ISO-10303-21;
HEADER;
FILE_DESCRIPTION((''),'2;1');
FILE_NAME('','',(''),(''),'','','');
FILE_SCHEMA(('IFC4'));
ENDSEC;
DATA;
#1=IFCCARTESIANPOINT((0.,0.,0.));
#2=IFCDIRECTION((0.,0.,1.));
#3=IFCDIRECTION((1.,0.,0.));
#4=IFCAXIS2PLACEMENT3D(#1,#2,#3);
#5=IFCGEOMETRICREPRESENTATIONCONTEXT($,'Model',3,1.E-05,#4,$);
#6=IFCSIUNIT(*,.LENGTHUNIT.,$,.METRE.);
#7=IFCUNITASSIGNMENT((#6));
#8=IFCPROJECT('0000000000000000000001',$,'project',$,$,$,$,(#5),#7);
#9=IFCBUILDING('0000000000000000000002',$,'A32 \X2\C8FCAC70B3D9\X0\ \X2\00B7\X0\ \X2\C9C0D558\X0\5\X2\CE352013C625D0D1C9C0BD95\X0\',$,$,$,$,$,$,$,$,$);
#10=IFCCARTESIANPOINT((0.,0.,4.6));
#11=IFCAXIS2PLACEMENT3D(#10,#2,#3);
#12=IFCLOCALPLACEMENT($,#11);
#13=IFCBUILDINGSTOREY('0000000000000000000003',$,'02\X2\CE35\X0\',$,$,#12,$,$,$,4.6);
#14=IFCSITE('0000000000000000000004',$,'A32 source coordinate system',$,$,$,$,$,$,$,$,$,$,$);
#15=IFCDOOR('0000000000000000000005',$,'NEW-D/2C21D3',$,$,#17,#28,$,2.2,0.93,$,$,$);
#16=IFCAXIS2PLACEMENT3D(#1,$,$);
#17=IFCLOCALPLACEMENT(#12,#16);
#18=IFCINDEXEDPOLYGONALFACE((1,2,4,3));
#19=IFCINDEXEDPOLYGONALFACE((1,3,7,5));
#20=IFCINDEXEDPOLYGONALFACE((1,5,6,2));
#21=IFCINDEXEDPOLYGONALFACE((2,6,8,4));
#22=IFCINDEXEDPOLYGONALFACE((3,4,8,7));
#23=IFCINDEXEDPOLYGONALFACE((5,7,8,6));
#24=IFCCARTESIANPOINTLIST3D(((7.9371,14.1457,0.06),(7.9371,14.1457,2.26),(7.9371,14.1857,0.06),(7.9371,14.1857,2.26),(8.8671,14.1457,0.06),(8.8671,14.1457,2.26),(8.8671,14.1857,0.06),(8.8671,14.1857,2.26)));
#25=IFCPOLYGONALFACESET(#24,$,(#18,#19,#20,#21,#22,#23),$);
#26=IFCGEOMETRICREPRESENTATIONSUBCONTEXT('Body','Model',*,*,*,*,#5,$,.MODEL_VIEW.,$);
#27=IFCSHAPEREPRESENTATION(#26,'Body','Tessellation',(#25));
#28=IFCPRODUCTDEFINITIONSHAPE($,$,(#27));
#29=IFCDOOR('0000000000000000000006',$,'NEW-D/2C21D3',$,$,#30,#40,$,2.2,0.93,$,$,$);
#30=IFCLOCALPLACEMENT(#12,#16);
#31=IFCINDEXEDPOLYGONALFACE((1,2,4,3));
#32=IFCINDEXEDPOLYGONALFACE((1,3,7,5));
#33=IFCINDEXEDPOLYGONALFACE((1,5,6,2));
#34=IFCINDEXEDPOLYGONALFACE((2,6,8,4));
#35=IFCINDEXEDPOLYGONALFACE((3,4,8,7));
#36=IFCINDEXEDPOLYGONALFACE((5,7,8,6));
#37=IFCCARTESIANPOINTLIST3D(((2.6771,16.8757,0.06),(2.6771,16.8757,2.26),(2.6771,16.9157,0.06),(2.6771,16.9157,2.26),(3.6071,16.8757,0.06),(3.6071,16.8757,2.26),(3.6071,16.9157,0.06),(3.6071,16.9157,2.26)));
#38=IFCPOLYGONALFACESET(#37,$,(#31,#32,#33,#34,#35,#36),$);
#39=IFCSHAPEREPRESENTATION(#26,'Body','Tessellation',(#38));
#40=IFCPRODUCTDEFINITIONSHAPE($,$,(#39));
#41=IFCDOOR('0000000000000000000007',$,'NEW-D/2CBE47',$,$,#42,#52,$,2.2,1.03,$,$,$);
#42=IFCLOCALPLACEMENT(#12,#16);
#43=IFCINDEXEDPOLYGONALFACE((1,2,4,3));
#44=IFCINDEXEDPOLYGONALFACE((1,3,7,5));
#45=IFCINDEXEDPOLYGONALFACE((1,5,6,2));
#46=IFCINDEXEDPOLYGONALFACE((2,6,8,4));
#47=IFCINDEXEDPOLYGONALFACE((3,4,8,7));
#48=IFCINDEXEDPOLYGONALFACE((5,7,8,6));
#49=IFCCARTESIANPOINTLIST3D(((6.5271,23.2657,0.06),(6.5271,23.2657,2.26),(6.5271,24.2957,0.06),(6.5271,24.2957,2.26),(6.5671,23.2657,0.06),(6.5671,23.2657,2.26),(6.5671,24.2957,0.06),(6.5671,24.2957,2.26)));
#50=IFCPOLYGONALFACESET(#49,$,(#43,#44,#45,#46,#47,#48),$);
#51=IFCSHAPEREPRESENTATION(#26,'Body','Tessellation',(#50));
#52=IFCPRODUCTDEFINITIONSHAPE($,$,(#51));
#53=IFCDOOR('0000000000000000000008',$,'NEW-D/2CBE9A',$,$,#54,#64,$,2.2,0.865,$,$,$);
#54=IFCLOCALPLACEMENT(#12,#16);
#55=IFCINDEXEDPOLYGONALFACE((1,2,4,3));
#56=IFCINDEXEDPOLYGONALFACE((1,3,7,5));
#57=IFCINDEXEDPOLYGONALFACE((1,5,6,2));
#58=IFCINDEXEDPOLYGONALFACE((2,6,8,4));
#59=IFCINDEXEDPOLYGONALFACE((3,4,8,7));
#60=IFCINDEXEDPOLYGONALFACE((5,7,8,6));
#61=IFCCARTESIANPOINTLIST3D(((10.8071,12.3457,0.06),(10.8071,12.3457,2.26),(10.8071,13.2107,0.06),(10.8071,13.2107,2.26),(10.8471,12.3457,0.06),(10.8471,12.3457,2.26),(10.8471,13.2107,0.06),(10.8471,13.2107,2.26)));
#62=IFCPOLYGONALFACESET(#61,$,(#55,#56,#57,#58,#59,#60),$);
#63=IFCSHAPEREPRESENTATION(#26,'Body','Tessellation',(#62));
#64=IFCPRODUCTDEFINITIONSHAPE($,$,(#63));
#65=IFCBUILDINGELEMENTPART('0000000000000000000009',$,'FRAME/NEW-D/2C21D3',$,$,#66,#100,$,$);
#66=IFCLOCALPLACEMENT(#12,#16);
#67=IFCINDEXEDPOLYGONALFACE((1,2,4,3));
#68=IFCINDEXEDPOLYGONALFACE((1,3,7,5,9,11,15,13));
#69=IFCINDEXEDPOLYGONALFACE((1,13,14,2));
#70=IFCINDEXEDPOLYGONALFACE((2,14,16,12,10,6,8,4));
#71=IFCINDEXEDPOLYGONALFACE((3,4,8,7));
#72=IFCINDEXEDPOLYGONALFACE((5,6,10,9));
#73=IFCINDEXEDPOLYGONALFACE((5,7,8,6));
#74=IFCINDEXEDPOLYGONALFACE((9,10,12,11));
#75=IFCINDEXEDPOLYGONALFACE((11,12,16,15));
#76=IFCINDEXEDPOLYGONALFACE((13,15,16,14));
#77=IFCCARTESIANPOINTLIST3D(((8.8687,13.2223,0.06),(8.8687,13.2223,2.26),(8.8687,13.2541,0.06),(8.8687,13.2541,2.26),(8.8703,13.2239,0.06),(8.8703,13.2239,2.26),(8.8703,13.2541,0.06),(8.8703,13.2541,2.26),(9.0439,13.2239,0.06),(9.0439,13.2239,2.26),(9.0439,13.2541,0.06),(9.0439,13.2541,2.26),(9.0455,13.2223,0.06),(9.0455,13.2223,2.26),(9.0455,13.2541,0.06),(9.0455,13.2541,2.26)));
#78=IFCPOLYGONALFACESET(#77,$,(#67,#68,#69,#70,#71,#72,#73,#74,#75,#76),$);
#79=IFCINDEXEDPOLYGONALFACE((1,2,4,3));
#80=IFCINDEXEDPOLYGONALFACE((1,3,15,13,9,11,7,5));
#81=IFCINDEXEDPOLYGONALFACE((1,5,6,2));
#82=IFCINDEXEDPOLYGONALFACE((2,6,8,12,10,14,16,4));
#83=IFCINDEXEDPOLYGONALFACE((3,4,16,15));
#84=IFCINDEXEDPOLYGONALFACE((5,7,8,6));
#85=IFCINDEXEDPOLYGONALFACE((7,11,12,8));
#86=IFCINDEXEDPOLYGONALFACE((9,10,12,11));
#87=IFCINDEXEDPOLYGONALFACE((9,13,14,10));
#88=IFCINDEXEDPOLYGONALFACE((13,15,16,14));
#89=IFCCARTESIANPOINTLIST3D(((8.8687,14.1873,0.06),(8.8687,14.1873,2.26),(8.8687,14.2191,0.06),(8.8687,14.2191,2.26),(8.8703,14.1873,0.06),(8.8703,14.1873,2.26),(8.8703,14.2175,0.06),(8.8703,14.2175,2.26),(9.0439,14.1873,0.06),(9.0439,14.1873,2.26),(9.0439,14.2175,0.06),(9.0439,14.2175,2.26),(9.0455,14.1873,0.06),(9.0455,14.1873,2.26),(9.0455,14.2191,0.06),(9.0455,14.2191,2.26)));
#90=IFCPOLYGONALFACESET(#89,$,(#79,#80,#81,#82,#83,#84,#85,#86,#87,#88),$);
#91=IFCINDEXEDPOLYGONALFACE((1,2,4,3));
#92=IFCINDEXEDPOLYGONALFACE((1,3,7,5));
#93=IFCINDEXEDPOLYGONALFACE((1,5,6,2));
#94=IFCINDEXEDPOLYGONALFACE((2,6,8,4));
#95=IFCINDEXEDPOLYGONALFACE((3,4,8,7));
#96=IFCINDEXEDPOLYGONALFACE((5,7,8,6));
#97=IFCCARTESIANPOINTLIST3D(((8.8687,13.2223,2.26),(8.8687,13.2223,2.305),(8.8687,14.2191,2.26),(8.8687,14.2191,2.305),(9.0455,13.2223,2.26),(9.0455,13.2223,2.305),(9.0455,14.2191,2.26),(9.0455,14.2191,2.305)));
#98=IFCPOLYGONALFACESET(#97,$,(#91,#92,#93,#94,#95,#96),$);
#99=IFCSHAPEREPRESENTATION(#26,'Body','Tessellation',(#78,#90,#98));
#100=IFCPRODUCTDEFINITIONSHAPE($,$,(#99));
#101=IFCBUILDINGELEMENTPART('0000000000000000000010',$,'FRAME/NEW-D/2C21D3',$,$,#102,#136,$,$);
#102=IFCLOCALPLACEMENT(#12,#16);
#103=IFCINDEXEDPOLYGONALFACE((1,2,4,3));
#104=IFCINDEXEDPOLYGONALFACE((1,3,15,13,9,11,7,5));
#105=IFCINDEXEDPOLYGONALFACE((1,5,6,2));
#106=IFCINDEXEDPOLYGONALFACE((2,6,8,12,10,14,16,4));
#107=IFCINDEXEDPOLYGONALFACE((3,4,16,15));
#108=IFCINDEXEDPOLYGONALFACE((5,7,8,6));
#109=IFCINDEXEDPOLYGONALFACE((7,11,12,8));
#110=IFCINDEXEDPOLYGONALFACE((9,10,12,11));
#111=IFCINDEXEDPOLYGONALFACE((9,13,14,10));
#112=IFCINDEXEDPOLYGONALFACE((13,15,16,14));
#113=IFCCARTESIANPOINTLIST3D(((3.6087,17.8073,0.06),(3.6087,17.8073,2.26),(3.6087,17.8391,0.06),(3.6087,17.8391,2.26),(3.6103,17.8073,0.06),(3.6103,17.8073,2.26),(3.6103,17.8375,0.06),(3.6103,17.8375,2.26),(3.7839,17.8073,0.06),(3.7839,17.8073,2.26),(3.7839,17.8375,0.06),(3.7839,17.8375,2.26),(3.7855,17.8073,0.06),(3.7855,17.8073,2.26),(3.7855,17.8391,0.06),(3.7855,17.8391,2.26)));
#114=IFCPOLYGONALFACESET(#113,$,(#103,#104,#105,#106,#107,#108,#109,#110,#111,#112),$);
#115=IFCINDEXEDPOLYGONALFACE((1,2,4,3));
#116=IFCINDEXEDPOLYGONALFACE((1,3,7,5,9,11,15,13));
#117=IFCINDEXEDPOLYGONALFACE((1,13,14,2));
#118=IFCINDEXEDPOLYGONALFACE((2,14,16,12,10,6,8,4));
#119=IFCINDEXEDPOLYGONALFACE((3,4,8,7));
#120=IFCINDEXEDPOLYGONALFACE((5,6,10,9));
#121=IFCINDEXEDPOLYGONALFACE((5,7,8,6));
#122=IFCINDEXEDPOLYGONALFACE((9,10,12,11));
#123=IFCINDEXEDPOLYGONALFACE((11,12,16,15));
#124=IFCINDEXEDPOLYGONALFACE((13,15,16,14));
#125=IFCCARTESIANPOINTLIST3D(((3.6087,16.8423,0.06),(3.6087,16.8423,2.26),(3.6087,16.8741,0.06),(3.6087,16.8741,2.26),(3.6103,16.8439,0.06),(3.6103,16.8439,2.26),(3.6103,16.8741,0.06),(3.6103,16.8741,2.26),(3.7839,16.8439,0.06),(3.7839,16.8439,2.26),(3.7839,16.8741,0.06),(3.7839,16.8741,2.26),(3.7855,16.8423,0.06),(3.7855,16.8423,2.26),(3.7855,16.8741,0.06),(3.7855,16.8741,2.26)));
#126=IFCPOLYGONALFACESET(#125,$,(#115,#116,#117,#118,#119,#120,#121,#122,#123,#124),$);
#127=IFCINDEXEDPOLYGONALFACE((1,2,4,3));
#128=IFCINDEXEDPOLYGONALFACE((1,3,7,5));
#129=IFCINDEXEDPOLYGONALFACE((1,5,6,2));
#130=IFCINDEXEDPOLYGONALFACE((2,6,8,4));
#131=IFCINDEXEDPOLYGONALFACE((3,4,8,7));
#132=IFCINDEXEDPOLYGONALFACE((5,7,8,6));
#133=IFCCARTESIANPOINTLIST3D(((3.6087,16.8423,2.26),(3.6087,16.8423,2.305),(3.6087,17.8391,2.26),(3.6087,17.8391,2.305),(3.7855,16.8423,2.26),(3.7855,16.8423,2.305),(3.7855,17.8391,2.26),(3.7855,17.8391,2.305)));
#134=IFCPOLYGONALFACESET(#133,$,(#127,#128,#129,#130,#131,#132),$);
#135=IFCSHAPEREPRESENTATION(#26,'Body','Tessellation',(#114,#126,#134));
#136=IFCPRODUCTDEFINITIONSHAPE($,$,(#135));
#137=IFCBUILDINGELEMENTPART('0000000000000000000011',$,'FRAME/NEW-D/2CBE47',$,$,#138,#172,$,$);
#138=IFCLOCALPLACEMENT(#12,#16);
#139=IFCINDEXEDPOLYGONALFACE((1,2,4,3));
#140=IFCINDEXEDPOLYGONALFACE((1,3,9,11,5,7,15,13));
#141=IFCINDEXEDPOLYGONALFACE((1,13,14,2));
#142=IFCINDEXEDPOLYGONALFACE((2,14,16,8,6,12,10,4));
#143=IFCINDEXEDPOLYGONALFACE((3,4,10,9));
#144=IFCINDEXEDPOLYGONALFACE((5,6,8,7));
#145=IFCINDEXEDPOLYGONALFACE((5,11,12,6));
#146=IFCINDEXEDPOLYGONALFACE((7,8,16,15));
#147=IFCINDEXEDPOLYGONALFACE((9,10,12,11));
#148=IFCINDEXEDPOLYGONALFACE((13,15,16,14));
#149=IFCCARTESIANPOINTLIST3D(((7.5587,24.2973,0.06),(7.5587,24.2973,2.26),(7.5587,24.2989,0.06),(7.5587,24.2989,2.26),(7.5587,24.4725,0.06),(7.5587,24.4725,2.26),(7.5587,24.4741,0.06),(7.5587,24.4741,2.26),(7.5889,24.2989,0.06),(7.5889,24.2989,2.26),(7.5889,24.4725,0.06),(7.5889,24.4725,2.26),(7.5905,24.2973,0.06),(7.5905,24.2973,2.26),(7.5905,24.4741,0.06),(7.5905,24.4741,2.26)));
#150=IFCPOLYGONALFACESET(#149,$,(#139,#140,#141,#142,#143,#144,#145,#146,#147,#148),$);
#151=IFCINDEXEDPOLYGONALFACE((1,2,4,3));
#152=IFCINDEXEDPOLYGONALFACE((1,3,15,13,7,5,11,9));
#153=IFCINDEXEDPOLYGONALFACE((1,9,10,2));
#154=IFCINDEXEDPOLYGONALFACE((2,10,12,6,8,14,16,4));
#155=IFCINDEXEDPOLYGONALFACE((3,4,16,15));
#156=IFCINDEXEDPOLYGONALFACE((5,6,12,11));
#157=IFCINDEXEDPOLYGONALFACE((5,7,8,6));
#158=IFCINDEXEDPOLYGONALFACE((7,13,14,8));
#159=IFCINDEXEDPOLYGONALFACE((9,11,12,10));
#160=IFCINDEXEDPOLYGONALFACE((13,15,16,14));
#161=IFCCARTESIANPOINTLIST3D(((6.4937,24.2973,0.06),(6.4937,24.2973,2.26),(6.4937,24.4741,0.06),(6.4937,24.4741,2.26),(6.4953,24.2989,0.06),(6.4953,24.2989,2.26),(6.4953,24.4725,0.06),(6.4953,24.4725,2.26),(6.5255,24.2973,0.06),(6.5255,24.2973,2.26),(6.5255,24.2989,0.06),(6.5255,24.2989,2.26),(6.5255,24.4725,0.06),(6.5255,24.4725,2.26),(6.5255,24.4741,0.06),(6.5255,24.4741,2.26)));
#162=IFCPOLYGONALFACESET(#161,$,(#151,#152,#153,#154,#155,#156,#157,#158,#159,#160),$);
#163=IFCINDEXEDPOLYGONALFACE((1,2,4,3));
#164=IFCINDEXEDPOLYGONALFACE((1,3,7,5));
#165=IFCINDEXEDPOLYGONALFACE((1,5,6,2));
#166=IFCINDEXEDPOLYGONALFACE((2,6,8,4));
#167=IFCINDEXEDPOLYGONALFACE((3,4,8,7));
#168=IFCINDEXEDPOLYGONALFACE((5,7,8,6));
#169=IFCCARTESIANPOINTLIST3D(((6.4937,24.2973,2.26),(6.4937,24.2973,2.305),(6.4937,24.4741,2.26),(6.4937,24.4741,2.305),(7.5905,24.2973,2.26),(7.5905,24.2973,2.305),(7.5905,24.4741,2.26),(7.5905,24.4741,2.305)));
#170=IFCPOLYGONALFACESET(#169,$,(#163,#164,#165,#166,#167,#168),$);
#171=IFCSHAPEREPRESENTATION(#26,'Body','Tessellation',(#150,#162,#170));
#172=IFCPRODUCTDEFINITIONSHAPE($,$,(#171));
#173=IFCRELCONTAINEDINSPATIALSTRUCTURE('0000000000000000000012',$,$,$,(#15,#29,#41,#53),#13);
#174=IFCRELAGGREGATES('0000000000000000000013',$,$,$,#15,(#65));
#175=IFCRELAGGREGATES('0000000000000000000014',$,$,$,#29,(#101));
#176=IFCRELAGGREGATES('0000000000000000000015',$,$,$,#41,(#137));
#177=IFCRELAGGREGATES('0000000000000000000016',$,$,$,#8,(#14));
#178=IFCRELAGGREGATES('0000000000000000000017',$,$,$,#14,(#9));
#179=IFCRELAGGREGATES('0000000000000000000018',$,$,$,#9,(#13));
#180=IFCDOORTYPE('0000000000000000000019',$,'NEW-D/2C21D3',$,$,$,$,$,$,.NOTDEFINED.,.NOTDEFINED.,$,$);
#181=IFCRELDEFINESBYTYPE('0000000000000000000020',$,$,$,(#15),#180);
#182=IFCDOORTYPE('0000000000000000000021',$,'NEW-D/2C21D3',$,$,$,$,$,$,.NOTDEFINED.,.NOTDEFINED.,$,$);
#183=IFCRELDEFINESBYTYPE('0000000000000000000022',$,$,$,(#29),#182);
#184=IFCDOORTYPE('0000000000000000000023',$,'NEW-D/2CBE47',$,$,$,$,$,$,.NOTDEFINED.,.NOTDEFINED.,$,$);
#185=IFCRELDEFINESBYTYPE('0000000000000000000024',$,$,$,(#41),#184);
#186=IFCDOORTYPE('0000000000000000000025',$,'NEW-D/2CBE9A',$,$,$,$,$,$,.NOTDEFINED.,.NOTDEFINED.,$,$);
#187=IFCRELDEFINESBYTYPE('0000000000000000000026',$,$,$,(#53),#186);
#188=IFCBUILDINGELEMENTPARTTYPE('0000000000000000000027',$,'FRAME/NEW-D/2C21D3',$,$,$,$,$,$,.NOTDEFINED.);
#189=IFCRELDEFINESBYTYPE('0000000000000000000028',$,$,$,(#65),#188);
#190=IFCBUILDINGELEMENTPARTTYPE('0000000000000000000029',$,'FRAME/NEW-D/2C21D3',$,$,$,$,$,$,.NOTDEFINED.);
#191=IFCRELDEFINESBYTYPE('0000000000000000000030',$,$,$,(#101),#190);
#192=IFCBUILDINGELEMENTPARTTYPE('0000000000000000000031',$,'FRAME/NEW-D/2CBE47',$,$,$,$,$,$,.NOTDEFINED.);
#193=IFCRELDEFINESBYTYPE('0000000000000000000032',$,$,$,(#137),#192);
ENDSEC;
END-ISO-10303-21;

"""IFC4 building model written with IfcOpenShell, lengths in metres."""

from ifc_helpers import new_model, si_unit, frame, origin, origin_with_axes, place, context, subcontext, project, spatial, polyline, outline, extrude, source, transform, mapped, type_object, type_shapes, element, aggregate, save


model = new_model("IFC4")

# Units and contexts
model_context = context("Model", 3, precision=1e-05, world=origin_with_axes())
body_context = subcontext(model_context, "Body", "Model", "MODEL_VIEW")
ifc_project = project(units=[si_unit("LENGTHUNIT", "METRE")], contexts=[model_context])

# Site, building, storey
site = spatial("IfcSite", under=ifc_project, Name="A32 source coordinate system")
building = spatial("IfcBuilding", under=site, Name="A32 주거동 · 지하5층–옥탑지붕")
storey_placement = place(None, frame((0.0, 0.0, 4.6), z_axis=(0.0, 0.0, 1.0), x_axis=(1.0, 0.0, 0.0)))
storey = spatial("IfcBuildingStorey", under=building, at=storey_placement, Name="02층", Elevation=4.6)

# Doors
door_type_1 = type_object("IfcDoorType", Name="NEW-D/2C21D3", OperationType="NOTDEFINED", PredefinedType="NOTDEFINED")
shared_shape_1 = source(origin(), body_context, "Body", "SweptSolid", [
    extrude(outline(polyline([(8.8671, 14.1857), (8.8671, 14.1457), (7.9371, 14.1457), (7.9371, 14.1857), (8.8671, 14.1857)])), frame((0.0, 0.0, 0.06)), (0.0, 0.0, 1.0), 2.2),
])
type_shapes(door_type_1, [shared_shape_1])
door_1_placement = place(storey_placement, origin_with_axes())
door_1 = element("IfcDoor", 1, at=door_1_placement, inside=storey, type_object=door_type_1, Name="NEW-D/2C21D3", OverallHeight=2.2, OverallWidth=0.93, context=body_context, shape_type="MappedRepresentation", body=[
    mapped(shared_shape_1, transform((0.0, 0.0, 0.0), scale=1.0)),
])
door_type_2 = type_object("IfcDoorType", Name="NEW-D/2C21D3", OperationType="NOTDEFINED", PredefinedType="NOTDEFINED")
shared_shape_2 = source(origin(), body_context, "Body", "SweptSolid", [
    extrude(outline(polyline([(2.6771, 16.9157), (3.6071, 16.9157), (3.6071, 16.8757), (2.6771, 16.8757), (2.6771, 16.9157)])), frame((0.0, 0.0, 0.06)), (0.0, 0.0, 1.0), 2.2),
])
type_shapes(door_type_2, [shared_shape_2])
door_2_placement = place(storey_placement, origin_with_axes())
door_2 = element("IfcDoor", 2, at=door_2_placement, inside=storey, type_object=door_type_2, Name="NEW-D/2C21D3", OverallHeight=2.2, OverallWidth=0.93, context=body_context, shape_type="MappedRepresentation", body=[
    mapped(shared_shape_2, transform((0.0, 0.0, 0.0), scale=1.0)),
])
door_type_3 = type_object("IfcDoorType", Name="NEW-D/2CBE47", OperationType="NOTDEFINED", PredefinedType="NOTDEFINED")
shared_shape_3 = source(origin(), body_context, "Body", "SweptSolid", [
    extrude(outline(polyline([(6.5271, 24.2957), (6.5671, 24.2957), (6.5671, 23.2657), (6.5271, 23.2657), (6.5271, 24.2957)])), frame((0.0, 0.0, 0.06)), (0.0, 0.0, 1.0), 2.2),
])
type_shapes(door_type_3, [shared_shape_3])
door_3_placement = place(storey_placement, origin_with_axes())
door_3 = element("IfcDoor", 3, at=door_3_placement, inside=storey, type_object=door_type_3, Name="NEW-D/2CBE47", OverallHeight=2.2, OverallWidth=1.03, context=body_context, shape_type="MappedRepresentation", body=[
    mapped(shared_shape_3, transform((0.0, 0.0, 0.0), scale=1.0)),
])
door_type_4 = type_object("IfcDoorType", Name="NEW-D/2CBE9A", OperationType="NOTDEFINED", PredefinedType="NOTDEFINED")
shared_shape_4 = source(origin(), body_context, "Body", "SweptSolid", [
    extrude(outline(polyline([(10.8471, 13.2107), (10.8471, 12.3457), (10.8071, 12.3457), (10.8071, 13.2107), (10.8471, 13.2107)])), frame((0.0, 0.0, 0.06)), (0.0, 0.0, 1.0), 2.2),
])
type_shapes(door_type_4, [shared_shape_4])
door_4_placement = place(storey_placement, origin_with_axes())
element("IfcDoor", 4, at=door_4_placement, inside=storey, type_object=door_type_4, Name="NEW-D/2CBE9A", OverallHeight=2.2, OverallWidth=0.865, context=body_context, shape_type="MappedRepresentation", body=[
    mapped(shared_shape_4, transform((0.0, 0.0, 0.0), scale=1.0)),
])

# Building element parts
building_element_part_type_1 = type_object("IfcBuildingElementPartType", Name="FRAME/NEW-D/2C21D3", PredefinedType="NOTDEFINED")
shared_shape_5 = source(origin(), body_context, "Body", "SweptSolid", [
    extrude(outline(polyline([(8.8703, 13.2239), (9.0439, 13.2239), (9.0439, 13.2541), (9.0455, 13.2541), (9.0455, 13.2223), (8.8687, 13.2223), (8.8687, 13.2541), (8.8703, 13.2541), (8.8703, 13.2239)])), frame((0.0, 0.0, 0.06)), (0.0, 0.0, 1.0), 2.2),
    extrude(outline(polyline([(9.0455, 14.2191), (9.0455, 14.1873), (9.0439, 14.1873), (9.0439, 14.2175), (8.8703, 14.2175), (8.8703, 14.1873), (8.8687, 14.1873), (8.8687, 14.2191), (9.0455, 14.2191)])), frame((0.0, 0.0, 0.06)), (0.0, 0.0, 1.0), 2.2),
    extrude(outline(polyline([(9.0455, 13.2223), (9.0455, 14.2191), (8.8687, 14.2191), (8.8687, 13.2223), (9.0455, 13.2223)])), frame((0.0, 0.0, 2.26)), (0.0, 0.0, 1.0), 0.045),
])
type_shapes(building_element_part_type_1, [shared_shape_5])
building_element_part_1_placement = place(door_1_placement, origin_with_axes())
building_element_part_1 = element("IfcBuildingElementPart", 5, at=building_element_part_1_placement, type_object=building_element_part_type_1, Name="FRAME/NEW-D/2C21D3", context=body_context, shape_type="MappedRepresentation", body=[
    mapped(shared_shape_5, transform((0.0, 0.0, 0.0), scale=1.0)),
])
aggregate(door_1, [building_element_part_1])
building_element_part_type_2 = type_object("IfcBuildingElementPartType", Name="FRAME/NEW-D/2C21D3", PredefinedType="NOTDEFINED")
shared_shape_6 = source(origin(), body_context, "Body", "SweptSolid", [
    extrude(outline(polyline([(3.7855, 17.8391), (3.7855, 17.8073), (3.7839, 17.8073), (3.7839, 17.8375), (3.6103, 17.8375), (3.6103, 17.8073), (3.6087, 17.8073), (3.6087, 17.8391), (3.7855, 17.8391)])), frame((0.0, 0.0, 0.06)), (0.0, 0.0, 1.0), 2.2),
    extrude(outline(polyline([(3.6103, 16.8439), (3.7839, 16.8439), (3.7839, 16.8741), (3.7855, 16.8741), (3.7855, 16.8423), (3.6087, 16.8423), (3.6087, 16.8741), (3.6103, 16.8741), (3.6103, 16.8439)])), frame((0.0, 0.0, 0.06)), (0.0, 0.0, 1.0), 2.2),
    extrude(outline(polyline([(3.7855, 16.8423), (3.7855, 17.8391), (3.6087, 17.8391), (3.6087, 16.8423), (3.7855, 16.8423)])), frame((0.0, 0.0, 2.26)), (0.0, 0.0, 1.0), 0.045),
])
type_shapes(building_element_part_type_2, [shared_shape_6])
building_element_part_2_placement = place(door_2_placement, origin_with_axes())
building_element_part_2 = element("IfcBuildingElementPart", 6, at=building_element_part_2_placement, type_object=building_element_part_type_2, Name="FRAME/NEW-D/2C21D3", context=body_context, shape_type="MappedRepresentation", body=[
    mapped(shared_shape_6, transform((0.0, 0.0, 0.0), scale=1.0)),
])
aggregate(door_2, [building_element_part_2])
building_element_part_type_3 = type_object("IfcBuildingElementPartType", Name="FRAME/NEW-D/2CBE47", PredefinedType="NOTDEFINED")
shared_shape_7 = source(origin(), body_context, "Body", "SweptSolid", [
    extrude(outline(polyline([(7.5889, 24.2989), (7.5889, 24.4725), (7.5587, 24.4725), (7.5587, 24.4741), (7.5905, 24.4741), (7.5905, 24.2973), (7.5587, 24.2973), (7.5587, 24.2989), (7.5889, 24.2989)])), frame((0.0, 0.0, 0.06)), (0.0, 0.0, 1.0), 2.2),
    extrude(outline(polyline([(6.4937, 24.4741), (6.5255, 24.4741), (6.5255, 24.4725), (6.4953, 24.4725), (6.4953, 24.2989), (6.5255, 24.2989), (6.5255, 24.2973), (6.4937, 24.2973), (6.4937, 24.4741)])), frame((0.0, 0.0, 0.06)), (0.0, 0.0, 1.0), 2.2),
    extrude(outline(polyline([(7.5905, 24.2973), (7.5905, 24.4741), (6.4937, 24.4741), (6.4937, 24.2973), (7.5905, 24.2973)])), frame((0.0, 0.0, 2.26)), (0.0, 0.0, 1.0), 0.045),
])
type_shapes(building_element_part_type_3, [shared_shape_7])
building_element_part_3_placement = place(door_3_placement, origin_with_axes())
building_element_part_3 = element("IfcBuildingElementPart", 7, at=building_element_part_3_placement, type_object=building_element_part_type_3, Name="FRAME/NEW-D/2CBE47", context=body_context, shape_type="MappedRepresentation", body=[
    mapped(shared_shape_7, transform((0.0, 0.0, 0.0), scale=1.0)),
])
aggregate(door_3, [building_element_part_3])

save(model, "model.ifc")
